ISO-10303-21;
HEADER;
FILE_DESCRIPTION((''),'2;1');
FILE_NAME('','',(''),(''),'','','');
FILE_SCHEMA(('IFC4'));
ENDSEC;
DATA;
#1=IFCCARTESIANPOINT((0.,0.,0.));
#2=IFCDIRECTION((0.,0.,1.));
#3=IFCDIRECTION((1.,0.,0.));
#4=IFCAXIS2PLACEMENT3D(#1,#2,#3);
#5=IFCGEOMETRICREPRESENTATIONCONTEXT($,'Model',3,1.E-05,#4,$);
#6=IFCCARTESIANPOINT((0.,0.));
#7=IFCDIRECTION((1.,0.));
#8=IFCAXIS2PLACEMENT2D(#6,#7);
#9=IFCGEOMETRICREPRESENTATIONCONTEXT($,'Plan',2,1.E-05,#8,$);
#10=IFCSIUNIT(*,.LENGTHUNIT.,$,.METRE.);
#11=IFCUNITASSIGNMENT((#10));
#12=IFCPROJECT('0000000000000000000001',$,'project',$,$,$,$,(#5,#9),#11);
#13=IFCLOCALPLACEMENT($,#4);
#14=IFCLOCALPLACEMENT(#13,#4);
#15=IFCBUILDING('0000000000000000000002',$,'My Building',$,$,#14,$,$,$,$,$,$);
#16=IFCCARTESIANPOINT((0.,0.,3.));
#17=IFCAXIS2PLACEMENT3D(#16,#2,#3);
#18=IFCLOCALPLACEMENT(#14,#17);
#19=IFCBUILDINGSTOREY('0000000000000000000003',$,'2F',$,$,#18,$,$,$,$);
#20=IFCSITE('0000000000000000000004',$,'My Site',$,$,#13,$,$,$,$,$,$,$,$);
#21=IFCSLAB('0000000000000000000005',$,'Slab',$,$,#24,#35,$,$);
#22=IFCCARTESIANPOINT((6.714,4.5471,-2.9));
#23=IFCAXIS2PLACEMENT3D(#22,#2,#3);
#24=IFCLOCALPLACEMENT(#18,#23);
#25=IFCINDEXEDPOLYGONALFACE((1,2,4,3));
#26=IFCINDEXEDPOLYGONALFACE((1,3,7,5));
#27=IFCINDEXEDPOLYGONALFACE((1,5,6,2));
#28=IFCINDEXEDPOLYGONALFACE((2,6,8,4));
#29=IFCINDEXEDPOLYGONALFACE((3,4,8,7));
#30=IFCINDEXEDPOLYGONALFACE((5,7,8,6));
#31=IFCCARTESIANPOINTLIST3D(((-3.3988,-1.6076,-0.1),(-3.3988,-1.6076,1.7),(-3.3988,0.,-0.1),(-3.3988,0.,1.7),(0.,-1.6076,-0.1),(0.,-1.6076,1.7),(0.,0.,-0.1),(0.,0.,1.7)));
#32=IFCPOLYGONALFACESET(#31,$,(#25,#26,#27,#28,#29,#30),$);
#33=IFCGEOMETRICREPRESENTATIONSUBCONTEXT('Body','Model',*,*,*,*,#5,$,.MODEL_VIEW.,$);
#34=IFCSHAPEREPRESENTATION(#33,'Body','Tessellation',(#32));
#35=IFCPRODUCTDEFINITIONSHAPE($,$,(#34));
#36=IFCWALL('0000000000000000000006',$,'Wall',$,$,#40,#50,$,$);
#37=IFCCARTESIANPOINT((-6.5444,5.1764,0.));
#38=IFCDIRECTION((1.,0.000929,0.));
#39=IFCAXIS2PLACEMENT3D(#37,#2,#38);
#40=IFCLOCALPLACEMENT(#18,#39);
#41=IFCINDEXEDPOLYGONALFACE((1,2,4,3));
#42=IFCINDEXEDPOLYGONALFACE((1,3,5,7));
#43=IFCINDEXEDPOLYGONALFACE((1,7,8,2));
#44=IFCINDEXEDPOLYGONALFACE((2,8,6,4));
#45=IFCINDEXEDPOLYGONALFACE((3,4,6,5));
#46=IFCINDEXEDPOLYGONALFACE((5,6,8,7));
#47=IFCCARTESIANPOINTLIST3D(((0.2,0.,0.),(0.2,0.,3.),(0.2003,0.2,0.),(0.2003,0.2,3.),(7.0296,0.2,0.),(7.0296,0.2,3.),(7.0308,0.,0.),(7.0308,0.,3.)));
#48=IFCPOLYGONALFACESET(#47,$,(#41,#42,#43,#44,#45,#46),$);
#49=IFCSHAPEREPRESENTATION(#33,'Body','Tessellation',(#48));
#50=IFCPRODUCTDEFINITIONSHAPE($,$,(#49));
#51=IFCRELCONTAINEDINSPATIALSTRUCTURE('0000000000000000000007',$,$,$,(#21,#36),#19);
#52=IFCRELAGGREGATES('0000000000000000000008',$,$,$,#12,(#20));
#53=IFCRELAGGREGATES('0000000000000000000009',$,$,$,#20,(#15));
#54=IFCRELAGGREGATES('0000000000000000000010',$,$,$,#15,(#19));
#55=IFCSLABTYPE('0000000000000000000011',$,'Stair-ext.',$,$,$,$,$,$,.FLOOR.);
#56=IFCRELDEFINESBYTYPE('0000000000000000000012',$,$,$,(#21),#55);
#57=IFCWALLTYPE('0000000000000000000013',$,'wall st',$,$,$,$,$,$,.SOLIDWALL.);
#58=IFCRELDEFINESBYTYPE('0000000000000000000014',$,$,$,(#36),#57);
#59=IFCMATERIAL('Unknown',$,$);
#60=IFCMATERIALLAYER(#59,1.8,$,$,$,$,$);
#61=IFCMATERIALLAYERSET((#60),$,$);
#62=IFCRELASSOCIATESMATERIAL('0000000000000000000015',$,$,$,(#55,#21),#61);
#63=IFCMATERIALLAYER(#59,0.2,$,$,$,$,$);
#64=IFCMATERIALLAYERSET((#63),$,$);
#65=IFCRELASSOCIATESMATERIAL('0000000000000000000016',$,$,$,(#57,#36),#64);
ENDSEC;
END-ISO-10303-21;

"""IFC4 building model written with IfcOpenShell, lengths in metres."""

from ifc_helpers import new_model, si_unit, frame, origin_with_axes, origin_2d_with_axis, place, context, subcontext, project, spatial, line, indexed_curve, outline, extrude, material, layer, layer_set, layer_usage, type_object, element, save


model = new_model("IFC4")

# Units and contexts
model_context = context("Model", 3, precision=1e-05, world=origin_with_axes())
plan_context = context("Plan", 2, precision=1e-05, world=origin_2d_with_axis())
body_context_1 = subcontext(model_context, "Body", "Model", "MODEL_VIEW")
ifc_project = project(units=[si_unit("LENGTHUNIT", "METRE")], contexts=[model_context, plan_context])

# Site, building, storey
site_placement = place(None, origin_with_axes())
site = spatial("IfcSite", under=ifc_project, at=site_placement, Name="My Site")
building_placement = place(site_placement, origin_with_axes())
building = spatial("IfcBuilding", under=site, at=building_placement, Name="My Building")
storey_placement = place(building_placement, frame((0.0, 0.0, 3.0), z_axis=(0.0, 0.0, 1.0), x_axis=(1.0, 0.0, 0.0)))
storey = spatial("IfcBuildingStorey", under=building, at=storey_placement, Name="2F")

# Slab
ifc_material = material(Name="Unknown")
ifc_layer_1 = layer(ifc_material, 1.8)
ifc_layer_set_1 = layer_set([ifc_layer_1])
ifc_layer_usage_1 = layer_usage(ifc_layer_set_1, "AXIS3", "POSITIVE", -0.1)
slab_type = type_object("IfcSlabType", Name="Stair-ext.", PredefinedType="FLOOR", material=ifc_layer_set_1)
slab_placement = place(storey_placement, frame((6.714, 4.5471, -2.9), z_axis=(0.0, 0.0, 1.0), x_axis=(1.0, 0.0, 0.0)))
element("IfcSlab", 1, at=slab_placement, inside=storey, type_object=slab_type, material=ifc_layer_usage_1, Name="Slab", context=body_context_1, shape_type="SweptSolid", body=[
    extrude(outline(indexed_curve([(0.0, 0.0), (0.0, -1.6076), (-3.3988, -1.6076), (-3.3988, 0.0), (0.0, 0.0)])), frame((0.0, 0.0, -0.1), z_axis=(0.0, 0.0, 1.0), x_axis=(1.0, 0.0, 0.0)), (0.0, 0.0, 1.0), 1.8),
])

# Shared definitions
ifc_layer_2 = layer(ifc_material, 0.2)
ifc_layer_set_2 = layer_set([ifc_layer_2])
wall_type_1 = type_object("IfcWallType", Name="wall st", PredefinedType="SOLIDWALL", material=ifc_layer_set_2)

# Wall
ifc_layer_usage_2 = layer_usage(ifc_layer_set_2, "AXIS2", "POSITIVE", 0.0)
wall_1_placement = place(storey_placement, frame((-6.5444, 5.1764, 0.0), z_axis=(0.0, 0.0, 1.0), x_axis=(1.0, 0.000929, 0.0)))
element("IfcWall", 2, at=wall_1_placement, inside=storey, type_object=wall_type_1, material=ifc_layer_usage_2, Name="Wall", context=body_context_1, shape_type="SweptSolid", body=[
    extrude(outline(indexed_curve([(0.2, 0.0), (0.2003, 0.2), (7.0296, 0.2), (7.0308, 0.0)], segments=[line(1, 2, 3, 4, 1)])), origin_with_axes(), (0.0, 0.0, 1.0), 3.0),
])

save(model, "model.ifc")
